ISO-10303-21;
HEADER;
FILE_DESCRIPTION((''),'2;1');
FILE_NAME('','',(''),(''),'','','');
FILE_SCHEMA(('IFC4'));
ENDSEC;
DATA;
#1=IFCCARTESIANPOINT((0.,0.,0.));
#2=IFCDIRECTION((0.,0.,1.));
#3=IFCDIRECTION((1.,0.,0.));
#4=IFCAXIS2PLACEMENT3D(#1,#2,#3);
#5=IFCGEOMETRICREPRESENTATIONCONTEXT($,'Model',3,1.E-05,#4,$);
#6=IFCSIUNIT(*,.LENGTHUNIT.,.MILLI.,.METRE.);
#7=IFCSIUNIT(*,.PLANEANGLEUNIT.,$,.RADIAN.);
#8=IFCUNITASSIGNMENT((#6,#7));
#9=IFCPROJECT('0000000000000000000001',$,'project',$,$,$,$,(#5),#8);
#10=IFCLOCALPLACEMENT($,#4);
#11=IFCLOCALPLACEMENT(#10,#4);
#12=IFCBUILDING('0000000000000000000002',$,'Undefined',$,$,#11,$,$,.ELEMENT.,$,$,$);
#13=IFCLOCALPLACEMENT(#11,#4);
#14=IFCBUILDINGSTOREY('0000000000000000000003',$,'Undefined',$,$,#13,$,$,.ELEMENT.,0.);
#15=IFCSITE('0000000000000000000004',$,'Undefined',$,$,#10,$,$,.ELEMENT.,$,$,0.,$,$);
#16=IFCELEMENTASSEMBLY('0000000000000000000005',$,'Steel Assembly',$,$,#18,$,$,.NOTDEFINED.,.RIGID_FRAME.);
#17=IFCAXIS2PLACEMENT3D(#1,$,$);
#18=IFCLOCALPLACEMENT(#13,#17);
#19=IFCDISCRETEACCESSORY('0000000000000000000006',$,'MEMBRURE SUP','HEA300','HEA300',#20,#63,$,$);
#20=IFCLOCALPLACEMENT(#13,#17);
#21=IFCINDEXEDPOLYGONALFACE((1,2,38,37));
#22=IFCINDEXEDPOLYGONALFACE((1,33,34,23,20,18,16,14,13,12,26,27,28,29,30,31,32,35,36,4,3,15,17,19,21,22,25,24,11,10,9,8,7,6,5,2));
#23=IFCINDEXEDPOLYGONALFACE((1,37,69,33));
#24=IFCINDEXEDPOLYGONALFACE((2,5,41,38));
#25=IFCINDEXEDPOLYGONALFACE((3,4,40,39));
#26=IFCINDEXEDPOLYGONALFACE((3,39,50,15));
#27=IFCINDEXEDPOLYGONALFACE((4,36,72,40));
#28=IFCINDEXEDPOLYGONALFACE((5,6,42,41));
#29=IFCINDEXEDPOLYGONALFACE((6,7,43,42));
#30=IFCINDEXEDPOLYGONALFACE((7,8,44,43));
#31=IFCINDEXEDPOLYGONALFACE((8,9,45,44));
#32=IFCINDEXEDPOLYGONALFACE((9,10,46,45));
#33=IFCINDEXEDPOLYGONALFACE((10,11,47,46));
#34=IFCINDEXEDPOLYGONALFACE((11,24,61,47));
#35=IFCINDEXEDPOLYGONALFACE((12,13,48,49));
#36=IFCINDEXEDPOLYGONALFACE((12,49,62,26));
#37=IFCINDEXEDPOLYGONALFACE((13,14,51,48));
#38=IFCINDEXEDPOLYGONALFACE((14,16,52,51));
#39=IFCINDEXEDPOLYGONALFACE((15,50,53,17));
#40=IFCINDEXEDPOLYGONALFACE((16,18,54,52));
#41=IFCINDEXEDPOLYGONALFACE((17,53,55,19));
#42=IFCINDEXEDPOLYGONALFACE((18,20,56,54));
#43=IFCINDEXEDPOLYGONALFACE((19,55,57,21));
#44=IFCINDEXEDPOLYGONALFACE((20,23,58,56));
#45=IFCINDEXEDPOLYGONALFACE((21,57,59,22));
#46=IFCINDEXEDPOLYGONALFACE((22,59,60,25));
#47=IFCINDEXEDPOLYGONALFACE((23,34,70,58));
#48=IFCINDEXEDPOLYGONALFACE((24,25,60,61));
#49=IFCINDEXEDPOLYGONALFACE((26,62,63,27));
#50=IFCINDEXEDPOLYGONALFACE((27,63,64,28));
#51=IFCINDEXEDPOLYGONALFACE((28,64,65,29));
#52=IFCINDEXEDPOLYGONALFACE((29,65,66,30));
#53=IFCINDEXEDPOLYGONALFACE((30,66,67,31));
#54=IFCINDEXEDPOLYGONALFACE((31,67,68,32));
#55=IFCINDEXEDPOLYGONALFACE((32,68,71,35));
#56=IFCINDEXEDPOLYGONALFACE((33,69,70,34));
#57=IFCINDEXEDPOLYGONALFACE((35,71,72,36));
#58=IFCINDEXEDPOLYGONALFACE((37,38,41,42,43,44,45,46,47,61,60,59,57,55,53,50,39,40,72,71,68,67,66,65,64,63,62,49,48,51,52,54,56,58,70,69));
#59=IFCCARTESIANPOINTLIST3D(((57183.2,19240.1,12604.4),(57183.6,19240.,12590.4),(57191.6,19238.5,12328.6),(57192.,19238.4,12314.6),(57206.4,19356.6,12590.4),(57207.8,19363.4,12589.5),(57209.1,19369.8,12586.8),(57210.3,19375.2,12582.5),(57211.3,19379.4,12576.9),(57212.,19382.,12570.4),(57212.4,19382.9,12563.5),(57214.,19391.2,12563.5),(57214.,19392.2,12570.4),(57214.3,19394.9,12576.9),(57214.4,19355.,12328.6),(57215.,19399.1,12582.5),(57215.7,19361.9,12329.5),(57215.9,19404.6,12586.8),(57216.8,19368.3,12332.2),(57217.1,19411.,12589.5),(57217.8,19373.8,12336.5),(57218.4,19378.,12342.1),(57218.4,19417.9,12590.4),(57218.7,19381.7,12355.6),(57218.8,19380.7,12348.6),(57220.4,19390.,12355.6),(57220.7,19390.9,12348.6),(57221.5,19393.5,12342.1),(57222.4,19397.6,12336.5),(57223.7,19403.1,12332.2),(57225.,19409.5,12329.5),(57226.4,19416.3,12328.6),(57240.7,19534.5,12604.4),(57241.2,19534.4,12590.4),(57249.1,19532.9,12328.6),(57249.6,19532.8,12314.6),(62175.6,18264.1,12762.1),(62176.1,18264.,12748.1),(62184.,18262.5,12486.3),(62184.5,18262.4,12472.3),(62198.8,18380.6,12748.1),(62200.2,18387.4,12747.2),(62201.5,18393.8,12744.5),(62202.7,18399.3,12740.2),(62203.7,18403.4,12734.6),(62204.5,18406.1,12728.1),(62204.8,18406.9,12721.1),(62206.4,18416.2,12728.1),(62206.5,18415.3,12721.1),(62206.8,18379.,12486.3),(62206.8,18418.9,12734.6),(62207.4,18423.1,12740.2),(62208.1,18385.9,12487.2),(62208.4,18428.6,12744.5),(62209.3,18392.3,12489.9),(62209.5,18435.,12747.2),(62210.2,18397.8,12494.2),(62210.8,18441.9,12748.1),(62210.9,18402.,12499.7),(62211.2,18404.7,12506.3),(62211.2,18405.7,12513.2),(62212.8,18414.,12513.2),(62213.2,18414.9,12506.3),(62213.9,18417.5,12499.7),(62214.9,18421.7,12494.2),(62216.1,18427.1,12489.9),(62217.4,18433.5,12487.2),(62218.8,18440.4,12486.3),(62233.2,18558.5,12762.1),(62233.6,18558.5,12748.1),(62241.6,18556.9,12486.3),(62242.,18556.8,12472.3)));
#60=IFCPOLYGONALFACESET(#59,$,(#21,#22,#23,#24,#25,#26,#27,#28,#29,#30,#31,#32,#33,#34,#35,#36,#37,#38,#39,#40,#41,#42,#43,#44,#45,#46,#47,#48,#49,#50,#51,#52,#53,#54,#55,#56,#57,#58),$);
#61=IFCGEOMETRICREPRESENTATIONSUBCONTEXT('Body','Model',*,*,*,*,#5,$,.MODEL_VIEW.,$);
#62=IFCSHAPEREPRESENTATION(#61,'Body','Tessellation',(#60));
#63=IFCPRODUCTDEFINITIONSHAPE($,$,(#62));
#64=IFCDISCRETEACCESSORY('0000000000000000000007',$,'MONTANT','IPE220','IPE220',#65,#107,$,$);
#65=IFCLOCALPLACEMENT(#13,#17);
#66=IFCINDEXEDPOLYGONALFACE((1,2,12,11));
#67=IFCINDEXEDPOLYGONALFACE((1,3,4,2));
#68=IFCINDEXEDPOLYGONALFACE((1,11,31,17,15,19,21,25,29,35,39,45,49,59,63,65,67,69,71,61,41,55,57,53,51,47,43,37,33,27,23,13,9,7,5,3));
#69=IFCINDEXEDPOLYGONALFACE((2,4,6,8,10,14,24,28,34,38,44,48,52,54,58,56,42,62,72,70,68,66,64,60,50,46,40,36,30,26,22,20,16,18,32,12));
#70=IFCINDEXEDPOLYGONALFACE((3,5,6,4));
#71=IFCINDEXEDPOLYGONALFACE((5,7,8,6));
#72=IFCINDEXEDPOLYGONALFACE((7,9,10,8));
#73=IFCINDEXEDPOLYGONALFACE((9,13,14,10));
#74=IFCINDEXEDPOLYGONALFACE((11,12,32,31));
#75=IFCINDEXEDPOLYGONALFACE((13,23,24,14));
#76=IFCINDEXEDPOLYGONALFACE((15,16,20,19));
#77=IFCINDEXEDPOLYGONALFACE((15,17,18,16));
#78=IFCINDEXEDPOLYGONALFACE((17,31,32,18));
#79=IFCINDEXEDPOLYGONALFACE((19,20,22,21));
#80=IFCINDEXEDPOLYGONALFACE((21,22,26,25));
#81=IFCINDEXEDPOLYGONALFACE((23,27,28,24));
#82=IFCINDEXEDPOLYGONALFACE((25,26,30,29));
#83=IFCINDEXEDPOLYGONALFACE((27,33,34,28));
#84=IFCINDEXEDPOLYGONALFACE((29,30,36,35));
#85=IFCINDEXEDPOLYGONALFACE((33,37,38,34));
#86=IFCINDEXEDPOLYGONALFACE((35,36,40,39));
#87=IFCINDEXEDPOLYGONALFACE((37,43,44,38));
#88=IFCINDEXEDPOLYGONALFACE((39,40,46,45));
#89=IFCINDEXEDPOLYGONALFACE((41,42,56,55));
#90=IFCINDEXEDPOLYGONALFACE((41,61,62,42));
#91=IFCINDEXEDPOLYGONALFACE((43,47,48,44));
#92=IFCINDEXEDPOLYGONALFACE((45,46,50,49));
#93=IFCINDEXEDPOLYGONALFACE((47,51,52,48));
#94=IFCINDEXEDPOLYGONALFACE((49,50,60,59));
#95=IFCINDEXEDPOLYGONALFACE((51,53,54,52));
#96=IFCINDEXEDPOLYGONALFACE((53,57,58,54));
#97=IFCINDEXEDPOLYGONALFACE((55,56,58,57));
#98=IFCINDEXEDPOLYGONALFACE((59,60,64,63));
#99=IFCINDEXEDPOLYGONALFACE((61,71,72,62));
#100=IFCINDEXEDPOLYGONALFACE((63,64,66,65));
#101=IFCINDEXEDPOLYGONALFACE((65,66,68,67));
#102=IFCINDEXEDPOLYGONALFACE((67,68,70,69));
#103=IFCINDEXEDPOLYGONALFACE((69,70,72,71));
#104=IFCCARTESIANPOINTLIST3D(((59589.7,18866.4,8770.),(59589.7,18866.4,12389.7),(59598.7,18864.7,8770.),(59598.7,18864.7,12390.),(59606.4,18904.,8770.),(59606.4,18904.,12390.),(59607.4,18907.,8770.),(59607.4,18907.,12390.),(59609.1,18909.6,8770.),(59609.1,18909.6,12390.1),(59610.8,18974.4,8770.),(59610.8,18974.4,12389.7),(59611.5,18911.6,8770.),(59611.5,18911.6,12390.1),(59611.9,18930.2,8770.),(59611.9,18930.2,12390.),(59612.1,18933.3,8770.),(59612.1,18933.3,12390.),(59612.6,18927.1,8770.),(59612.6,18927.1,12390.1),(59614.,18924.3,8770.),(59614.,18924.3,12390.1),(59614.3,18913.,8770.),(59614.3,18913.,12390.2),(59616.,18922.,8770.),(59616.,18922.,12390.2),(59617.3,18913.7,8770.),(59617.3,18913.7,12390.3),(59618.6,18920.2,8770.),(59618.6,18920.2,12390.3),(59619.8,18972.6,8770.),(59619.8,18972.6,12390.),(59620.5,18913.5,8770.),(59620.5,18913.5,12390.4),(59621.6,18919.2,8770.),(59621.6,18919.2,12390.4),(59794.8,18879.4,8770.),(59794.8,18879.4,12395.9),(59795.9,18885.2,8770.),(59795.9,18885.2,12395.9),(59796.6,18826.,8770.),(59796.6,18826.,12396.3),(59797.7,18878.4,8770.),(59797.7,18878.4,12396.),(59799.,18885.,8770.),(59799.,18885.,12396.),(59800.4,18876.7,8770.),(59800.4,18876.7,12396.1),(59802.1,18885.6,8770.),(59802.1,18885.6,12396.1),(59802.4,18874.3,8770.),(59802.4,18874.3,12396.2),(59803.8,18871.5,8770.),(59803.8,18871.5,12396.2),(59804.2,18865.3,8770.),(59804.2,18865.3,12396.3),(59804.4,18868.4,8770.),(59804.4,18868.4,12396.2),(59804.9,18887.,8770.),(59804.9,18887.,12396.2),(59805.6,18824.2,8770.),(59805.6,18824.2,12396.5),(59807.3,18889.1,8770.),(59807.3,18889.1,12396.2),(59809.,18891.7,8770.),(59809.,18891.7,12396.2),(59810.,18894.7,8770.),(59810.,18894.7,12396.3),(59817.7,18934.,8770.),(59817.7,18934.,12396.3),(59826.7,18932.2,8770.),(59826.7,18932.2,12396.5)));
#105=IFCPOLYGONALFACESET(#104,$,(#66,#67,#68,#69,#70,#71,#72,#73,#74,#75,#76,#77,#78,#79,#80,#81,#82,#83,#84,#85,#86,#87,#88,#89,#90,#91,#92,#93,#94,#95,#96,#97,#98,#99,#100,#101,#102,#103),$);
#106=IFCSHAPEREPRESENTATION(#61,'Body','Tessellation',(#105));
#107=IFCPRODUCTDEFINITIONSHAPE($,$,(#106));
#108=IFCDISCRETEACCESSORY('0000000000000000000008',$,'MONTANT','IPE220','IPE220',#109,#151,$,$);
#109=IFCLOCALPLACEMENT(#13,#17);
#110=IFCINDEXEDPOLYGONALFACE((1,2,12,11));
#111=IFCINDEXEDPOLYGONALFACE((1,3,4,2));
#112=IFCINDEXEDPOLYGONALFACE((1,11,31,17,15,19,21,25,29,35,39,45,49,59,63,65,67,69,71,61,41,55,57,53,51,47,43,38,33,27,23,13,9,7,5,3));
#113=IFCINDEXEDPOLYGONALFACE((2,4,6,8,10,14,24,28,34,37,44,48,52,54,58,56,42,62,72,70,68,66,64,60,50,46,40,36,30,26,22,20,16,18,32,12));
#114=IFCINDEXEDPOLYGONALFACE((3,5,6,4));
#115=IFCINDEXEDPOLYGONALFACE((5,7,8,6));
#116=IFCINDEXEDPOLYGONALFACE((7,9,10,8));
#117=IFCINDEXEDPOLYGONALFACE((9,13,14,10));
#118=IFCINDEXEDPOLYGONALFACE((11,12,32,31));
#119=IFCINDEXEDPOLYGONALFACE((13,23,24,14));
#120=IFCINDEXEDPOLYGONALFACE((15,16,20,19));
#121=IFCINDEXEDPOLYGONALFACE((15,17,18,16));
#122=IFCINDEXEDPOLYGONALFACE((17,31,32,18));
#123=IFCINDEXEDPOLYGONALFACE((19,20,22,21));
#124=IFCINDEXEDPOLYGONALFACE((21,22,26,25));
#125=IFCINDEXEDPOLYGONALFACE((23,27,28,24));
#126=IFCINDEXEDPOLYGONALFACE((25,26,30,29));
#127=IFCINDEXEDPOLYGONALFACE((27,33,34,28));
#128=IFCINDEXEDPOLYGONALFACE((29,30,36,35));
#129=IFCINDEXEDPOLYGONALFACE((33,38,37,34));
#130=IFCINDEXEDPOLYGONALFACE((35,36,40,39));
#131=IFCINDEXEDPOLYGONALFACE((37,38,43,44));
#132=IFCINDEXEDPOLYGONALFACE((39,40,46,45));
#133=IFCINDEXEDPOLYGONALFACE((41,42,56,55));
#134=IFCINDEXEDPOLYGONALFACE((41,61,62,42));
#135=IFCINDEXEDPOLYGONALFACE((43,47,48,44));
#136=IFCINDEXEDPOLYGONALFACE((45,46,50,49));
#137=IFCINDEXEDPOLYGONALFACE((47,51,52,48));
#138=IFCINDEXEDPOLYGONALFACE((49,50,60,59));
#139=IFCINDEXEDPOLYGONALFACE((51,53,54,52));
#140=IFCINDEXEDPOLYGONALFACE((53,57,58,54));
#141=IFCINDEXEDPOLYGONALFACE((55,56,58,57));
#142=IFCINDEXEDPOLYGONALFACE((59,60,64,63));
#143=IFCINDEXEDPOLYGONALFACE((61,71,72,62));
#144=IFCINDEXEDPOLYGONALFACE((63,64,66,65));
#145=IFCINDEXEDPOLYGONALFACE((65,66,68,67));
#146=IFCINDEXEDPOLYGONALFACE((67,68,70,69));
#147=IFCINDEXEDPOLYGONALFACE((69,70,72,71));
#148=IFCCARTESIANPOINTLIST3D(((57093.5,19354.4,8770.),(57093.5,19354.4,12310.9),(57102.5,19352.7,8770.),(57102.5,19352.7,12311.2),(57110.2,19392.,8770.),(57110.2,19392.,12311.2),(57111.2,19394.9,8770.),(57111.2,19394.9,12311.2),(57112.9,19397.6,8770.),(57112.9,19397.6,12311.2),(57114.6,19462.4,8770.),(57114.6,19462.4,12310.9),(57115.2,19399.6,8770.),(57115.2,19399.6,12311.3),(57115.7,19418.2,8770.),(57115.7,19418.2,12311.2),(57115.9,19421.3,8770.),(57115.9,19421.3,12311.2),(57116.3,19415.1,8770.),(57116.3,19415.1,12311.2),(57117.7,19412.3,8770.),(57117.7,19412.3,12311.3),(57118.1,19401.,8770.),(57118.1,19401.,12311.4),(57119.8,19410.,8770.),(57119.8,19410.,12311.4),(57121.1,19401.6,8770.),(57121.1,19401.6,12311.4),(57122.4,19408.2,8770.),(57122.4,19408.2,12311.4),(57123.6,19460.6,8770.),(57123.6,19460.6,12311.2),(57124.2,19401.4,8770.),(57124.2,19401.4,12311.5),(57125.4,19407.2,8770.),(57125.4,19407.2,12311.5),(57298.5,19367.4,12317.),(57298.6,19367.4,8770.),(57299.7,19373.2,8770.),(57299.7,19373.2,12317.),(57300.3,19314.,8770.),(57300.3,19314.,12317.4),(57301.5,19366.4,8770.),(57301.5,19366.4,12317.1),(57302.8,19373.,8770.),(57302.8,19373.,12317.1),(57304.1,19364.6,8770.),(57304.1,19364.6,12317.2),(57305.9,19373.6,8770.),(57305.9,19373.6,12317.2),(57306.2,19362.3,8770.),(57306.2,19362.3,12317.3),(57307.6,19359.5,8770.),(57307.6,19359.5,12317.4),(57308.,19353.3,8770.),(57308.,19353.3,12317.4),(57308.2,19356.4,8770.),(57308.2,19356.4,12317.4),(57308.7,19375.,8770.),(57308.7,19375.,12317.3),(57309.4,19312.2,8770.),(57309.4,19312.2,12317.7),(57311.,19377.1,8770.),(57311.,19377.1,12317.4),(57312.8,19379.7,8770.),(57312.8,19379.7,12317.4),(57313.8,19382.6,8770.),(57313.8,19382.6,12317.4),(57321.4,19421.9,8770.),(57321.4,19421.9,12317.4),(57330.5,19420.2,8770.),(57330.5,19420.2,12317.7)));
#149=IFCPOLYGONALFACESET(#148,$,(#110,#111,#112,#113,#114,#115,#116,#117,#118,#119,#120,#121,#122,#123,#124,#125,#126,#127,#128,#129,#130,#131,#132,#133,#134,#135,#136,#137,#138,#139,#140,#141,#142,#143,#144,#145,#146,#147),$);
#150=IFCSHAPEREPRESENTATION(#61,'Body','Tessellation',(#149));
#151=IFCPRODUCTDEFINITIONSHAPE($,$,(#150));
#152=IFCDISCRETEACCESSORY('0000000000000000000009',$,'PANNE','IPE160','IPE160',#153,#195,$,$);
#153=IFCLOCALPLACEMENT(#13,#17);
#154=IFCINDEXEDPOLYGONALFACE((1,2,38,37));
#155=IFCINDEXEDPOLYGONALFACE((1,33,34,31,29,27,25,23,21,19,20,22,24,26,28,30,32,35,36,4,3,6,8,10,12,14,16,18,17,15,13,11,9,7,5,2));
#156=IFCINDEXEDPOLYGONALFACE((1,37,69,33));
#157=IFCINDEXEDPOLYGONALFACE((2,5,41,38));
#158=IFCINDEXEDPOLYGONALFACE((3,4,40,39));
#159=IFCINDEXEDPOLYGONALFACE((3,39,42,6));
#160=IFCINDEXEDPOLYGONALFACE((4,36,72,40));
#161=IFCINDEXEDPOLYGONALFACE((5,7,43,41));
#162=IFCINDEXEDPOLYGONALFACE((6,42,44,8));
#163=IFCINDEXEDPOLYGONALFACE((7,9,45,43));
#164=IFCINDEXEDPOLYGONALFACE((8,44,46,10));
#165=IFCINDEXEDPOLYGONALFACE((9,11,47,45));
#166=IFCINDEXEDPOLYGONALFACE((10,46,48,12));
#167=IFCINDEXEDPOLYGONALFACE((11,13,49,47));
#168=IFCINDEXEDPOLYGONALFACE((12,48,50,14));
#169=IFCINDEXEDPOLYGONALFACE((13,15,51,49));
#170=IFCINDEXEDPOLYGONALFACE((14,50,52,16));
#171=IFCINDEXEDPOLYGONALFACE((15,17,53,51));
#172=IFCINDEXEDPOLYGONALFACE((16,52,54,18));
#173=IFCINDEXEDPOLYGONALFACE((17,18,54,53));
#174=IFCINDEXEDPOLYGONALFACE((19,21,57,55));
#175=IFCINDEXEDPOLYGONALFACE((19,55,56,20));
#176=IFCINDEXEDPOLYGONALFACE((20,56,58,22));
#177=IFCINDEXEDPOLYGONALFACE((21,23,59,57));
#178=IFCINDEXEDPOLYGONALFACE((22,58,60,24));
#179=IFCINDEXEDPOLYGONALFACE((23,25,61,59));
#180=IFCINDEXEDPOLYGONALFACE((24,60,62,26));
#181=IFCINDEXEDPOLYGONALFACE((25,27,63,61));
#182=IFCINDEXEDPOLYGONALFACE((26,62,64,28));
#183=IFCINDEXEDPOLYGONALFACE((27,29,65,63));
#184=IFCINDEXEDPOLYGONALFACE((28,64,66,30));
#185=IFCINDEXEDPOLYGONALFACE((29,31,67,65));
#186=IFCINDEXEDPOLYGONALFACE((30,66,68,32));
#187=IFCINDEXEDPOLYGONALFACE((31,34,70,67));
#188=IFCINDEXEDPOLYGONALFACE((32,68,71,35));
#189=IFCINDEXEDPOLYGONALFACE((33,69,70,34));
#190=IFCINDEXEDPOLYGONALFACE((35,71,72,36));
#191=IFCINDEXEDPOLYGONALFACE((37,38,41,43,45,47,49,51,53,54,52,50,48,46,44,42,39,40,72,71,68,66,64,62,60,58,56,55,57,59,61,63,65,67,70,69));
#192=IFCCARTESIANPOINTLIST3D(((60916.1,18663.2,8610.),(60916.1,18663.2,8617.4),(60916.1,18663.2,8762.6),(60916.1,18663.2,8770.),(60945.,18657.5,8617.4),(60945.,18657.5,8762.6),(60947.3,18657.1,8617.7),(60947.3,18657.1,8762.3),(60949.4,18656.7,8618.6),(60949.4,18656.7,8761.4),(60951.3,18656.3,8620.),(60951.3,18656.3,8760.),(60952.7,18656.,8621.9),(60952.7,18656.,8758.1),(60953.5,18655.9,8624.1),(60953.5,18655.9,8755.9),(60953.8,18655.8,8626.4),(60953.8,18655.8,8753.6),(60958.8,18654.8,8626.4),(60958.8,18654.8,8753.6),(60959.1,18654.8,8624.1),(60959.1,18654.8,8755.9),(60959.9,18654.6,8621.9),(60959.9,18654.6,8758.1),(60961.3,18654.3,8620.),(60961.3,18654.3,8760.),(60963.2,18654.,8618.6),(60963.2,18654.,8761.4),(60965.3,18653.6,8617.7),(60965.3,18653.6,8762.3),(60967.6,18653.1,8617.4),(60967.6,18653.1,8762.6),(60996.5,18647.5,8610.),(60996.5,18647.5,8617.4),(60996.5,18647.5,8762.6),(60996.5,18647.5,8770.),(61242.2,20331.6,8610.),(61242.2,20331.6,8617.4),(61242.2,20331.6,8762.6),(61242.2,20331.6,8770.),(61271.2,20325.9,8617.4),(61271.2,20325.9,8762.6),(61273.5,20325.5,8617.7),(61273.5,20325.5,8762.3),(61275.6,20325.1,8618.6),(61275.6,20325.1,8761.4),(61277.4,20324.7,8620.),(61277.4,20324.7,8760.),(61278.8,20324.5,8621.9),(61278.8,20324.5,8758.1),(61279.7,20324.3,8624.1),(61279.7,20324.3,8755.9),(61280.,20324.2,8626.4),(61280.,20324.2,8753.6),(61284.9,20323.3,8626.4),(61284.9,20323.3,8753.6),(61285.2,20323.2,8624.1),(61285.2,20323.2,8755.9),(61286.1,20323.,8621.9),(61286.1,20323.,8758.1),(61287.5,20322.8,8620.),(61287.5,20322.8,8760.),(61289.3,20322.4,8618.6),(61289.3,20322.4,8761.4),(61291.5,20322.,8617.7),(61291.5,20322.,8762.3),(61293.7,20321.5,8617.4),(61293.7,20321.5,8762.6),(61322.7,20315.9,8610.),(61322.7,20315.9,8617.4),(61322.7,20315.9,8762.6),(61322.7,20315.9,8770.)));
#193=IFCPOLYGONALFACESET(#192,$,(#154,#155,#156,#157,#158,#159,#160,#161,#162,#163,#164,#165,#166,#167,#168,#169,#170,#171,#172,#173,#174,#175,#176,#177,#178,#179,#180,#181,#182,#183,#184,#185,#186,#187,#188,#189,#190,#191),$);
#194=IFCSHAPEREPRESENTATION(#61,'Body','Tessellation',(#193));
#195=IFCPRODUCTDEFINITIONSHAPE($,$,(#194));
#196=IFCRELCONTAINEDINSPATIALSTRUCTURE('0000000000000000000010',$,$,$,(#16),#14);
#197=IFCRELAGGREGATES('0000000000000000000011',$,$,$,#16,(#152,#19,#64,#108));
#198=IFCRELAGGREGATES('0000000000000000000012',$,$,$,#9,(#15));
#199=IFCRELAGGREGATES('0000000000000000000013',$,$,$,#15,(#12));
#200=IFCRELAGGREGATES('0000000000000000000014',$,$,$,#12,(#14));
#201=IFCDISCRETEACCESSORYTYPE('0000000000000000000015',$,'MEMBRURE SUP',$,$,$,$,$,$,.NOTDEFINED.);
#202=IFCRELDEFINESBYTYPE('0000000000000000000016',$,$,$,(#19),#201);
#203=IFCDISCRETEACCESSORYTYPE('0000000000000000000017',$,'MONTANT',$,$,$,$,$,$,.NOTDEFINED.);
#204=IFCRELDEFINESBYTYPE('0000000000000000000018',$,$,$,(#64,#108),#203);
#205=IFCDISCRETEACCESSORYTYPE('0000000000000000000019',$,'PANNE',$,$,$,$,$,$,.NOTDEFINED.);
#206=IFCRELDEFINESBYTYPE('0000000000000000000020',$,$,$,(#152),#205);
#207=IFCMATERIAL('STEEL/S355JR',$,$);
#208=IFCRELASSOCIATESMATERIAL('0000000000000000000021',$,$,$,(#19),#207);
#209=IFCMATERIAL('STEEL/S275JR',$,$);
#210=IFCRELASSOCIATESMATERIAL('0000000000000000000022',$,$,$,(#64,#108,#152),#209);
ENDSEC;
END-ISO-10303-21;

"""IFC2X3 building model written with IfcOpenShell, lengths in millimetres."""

from ifc_helpers import new_model, si_unit, frame, origin_with_axes, origin_2d_with_axis, place, context, subcontext, project, spatial, i_section, extrude, clip, halfspace, material, type_object, element, aggregate, save


model = new_model("IFC2X3")

# Units and contexts
model_context = context("Model", 3, precision=1e-05, world=origin_with_axes())
body_context = subcontext(model_context, "Body", "Model", "MODEL_VIEW")
ifc_project = project(units=[si_unit("LENGTHUNIT", "METRE", prefix="MILLI"), si_unit("PLANEANGLEUNIT", "RADIAN")], contexts=[model_context])

# Site, building, storey
site_placement = place(None, origin_with_axes())
site = spatial("IfcSite", under=ifc_project, at=site_placement, Name="Undefined", CompositionType="ELEMENT", RefElevation=0.0)
building_placement = place(site_placement, origin_with_axes())
building = spatial("IfcBuilding", under=site, at=building_placement, Name="Undefined", CompositionType="ELEMENT")
storey_placement = place(building_placement, origin_with_axes())
storey = spatial("IfcBuildingStorey", under=building, at=storey_placement, Name="Undefined", CompositionType="ELEMENT", Elevation=0.0)

# Shared definitions
ifc_material_1 = material(Name="STEEL/S275JR")

# Element assembly, discrete accessories
assembly_1_placement = place(storey_placement, origin_with_axes())
assembly_1 = element("IfcElementAssembly", 1, at=assembly_1_placement, inside=storey, Name="Steel Assembly", AssemblyPlace="NOTDEFINED", PredefinedType="RIGID_FRAME")
ifc_material_2 = material(Name="STEEL/S355JR")
discrete_accessory_type_1 = type_object("IfcDiscreteAccessoryType", Name="MEMBRURE SUP")
discrete_accessory_1_placement = place(assembly_1_placement, frame((57216.4, 19386.4, 12459.5), z_axis=(-0.030408, 0.005945, 0.99952), x_axis=(0.980951, -0.191767, 0.030984)))
discrete_accessory_1 = element("IfcDiscreteAccessory", 2, at=discrete_accessory_1_placement, type_object=discrete_accessory_type_1, material=ifc_material_2, Name="MEMBRURE SUP", Description="HEA300", ObjectType="HEA300", context=body_context, shape_type="SweptSolid", body=[
    extrude(i_section(OverallWidth=300.0, OverallDepth=290.0, WebThickness=8.5, FlangeThickness=14.0, FilletRadius=27.0, at=origin_2d_with_axis()), frame((5089.4, 0.0, 0.0), z_axis=(-1.0, 0.0, 0.0), x_axis=(0.0, -1.0, 0.0)), (0.0, 0.0, 1.0), 5089.4),
])
discrete_accessory_type_2 = type_object("IfcDiscreteAccessoryType", Name="MONTANT")
discrete_accessory_2_placement = place(assembly_1_placement, frame((59708.2, 18899.3, 12368.9), z_axis=(0.981422, -0.191859, 0.0), x_axis=(0.0, 0.0, -1.0)))
discrete_accessory_2 = element("IfcDiscreteAccessory", 3, at=discrete_accessory_2_placement, type_object=discrete_accessory_type_2, material=ifc_material_1, Name="MONTANT", Description="IPE220", ObjectType="IPE220", context=body_context, shape_type="Clipping", body=[
    clip(extrude(i_section(OverallWidth=110.0, OverallDepth=220.0, WebThickness=5.9, FlangeThickness=9.2, FilletRadius=12.0, at=origin_2d_with_axis()), frame((3598.9, 0.0, 0.0), z_axis=(-1.0, 0.0, 0.0), x_axis=(0.0, -1.0, 0.0)), (0.0, 0.0, 1.0), 3626.6), halfspace(frame((-20.6, -150.0, -115.3), z_axis=(0.99952, 0.0, 0.030984), x_axis=(0.0, -1.0, 0.0)), True)),
])
discrete_accessory_3_placement = place(assembly_1_placement, frame((57212.0, 19387.3, 12290.1), z_axis=(0.981422, -0.191859, 0.0), x_axis=(0.0, 0.0, -1.0)))
discrete_accessory_3 = element("IfcDiscreteAccessory", 4, at=discrete_accessory_3_placement, type_object=discrete_accessory_type_2, material=ifc_material_1, Name="MONTANT", Description="IPE220", ObjectType="IPE220", context=body_context, shape_type="Clipping", body=[
    clip(extrude(i_section(OverallWidth=110.0, OverallDepth=220.0, WebThickness=5.9, FlangeThickness=9.2, FilletRadius=12.0, at=origin_2d_with_axis()), frame((3520.1, 0.0, 0.0), z_axis=(-1.0, 0.0, 0.0), x_axis=(0.0, -1.0, 0.0)), (0.0, 0.0, 1.0), 3547.7), halfspace(frame((-23.1, -150.0, -35.7), z_axis=(0.99952, 0.0, 0.030984), x_axis=(0.0, -1.0, 0.0)), True)),
])
discrete_accessory_type_3 = type_object("IfcDiscreteAccessoryType", Name="PANNE")
discrete_accessory_4_placement = place(assembly_1_placement, frame((60956.3, 18655.3, 8690.0), z_axis=(0.0, 0.0, 1.0), x_axis=(0.191859, 0.981422, 0.0)))
discrete_accessory_4 = element("IfcDiscreteAccessory", 5, at=discrete_accessory_4_placement, type_object=discrete_accessory_type_3, material=ifc_material_1, Name="PANNE", Description="IPE160", ObjectType="IPE160", context=body_context, shape_type="SweptSolid", body=[
    extrude(i_section(OverallWidth=82.0, OverallDepth=160.0, WebThickness=5.0, FlangeThickness=7.4, FilletRadius=9.0, at=origin_2d_with_axis()), frame((1700.0, 0.0, 0.0), z_axis=(-1.0, 0.0, 0.0), x_axis=(0.0, -1.0, 0.0)), (0.0, 0.0, 1.0), 1700.0),
])
aggregate(assembly_1, [discrete_accessory_4, discrete_accessory_1, discrete_accessory_2, discrete_accessory_3])

save(model, "model.ifc")
